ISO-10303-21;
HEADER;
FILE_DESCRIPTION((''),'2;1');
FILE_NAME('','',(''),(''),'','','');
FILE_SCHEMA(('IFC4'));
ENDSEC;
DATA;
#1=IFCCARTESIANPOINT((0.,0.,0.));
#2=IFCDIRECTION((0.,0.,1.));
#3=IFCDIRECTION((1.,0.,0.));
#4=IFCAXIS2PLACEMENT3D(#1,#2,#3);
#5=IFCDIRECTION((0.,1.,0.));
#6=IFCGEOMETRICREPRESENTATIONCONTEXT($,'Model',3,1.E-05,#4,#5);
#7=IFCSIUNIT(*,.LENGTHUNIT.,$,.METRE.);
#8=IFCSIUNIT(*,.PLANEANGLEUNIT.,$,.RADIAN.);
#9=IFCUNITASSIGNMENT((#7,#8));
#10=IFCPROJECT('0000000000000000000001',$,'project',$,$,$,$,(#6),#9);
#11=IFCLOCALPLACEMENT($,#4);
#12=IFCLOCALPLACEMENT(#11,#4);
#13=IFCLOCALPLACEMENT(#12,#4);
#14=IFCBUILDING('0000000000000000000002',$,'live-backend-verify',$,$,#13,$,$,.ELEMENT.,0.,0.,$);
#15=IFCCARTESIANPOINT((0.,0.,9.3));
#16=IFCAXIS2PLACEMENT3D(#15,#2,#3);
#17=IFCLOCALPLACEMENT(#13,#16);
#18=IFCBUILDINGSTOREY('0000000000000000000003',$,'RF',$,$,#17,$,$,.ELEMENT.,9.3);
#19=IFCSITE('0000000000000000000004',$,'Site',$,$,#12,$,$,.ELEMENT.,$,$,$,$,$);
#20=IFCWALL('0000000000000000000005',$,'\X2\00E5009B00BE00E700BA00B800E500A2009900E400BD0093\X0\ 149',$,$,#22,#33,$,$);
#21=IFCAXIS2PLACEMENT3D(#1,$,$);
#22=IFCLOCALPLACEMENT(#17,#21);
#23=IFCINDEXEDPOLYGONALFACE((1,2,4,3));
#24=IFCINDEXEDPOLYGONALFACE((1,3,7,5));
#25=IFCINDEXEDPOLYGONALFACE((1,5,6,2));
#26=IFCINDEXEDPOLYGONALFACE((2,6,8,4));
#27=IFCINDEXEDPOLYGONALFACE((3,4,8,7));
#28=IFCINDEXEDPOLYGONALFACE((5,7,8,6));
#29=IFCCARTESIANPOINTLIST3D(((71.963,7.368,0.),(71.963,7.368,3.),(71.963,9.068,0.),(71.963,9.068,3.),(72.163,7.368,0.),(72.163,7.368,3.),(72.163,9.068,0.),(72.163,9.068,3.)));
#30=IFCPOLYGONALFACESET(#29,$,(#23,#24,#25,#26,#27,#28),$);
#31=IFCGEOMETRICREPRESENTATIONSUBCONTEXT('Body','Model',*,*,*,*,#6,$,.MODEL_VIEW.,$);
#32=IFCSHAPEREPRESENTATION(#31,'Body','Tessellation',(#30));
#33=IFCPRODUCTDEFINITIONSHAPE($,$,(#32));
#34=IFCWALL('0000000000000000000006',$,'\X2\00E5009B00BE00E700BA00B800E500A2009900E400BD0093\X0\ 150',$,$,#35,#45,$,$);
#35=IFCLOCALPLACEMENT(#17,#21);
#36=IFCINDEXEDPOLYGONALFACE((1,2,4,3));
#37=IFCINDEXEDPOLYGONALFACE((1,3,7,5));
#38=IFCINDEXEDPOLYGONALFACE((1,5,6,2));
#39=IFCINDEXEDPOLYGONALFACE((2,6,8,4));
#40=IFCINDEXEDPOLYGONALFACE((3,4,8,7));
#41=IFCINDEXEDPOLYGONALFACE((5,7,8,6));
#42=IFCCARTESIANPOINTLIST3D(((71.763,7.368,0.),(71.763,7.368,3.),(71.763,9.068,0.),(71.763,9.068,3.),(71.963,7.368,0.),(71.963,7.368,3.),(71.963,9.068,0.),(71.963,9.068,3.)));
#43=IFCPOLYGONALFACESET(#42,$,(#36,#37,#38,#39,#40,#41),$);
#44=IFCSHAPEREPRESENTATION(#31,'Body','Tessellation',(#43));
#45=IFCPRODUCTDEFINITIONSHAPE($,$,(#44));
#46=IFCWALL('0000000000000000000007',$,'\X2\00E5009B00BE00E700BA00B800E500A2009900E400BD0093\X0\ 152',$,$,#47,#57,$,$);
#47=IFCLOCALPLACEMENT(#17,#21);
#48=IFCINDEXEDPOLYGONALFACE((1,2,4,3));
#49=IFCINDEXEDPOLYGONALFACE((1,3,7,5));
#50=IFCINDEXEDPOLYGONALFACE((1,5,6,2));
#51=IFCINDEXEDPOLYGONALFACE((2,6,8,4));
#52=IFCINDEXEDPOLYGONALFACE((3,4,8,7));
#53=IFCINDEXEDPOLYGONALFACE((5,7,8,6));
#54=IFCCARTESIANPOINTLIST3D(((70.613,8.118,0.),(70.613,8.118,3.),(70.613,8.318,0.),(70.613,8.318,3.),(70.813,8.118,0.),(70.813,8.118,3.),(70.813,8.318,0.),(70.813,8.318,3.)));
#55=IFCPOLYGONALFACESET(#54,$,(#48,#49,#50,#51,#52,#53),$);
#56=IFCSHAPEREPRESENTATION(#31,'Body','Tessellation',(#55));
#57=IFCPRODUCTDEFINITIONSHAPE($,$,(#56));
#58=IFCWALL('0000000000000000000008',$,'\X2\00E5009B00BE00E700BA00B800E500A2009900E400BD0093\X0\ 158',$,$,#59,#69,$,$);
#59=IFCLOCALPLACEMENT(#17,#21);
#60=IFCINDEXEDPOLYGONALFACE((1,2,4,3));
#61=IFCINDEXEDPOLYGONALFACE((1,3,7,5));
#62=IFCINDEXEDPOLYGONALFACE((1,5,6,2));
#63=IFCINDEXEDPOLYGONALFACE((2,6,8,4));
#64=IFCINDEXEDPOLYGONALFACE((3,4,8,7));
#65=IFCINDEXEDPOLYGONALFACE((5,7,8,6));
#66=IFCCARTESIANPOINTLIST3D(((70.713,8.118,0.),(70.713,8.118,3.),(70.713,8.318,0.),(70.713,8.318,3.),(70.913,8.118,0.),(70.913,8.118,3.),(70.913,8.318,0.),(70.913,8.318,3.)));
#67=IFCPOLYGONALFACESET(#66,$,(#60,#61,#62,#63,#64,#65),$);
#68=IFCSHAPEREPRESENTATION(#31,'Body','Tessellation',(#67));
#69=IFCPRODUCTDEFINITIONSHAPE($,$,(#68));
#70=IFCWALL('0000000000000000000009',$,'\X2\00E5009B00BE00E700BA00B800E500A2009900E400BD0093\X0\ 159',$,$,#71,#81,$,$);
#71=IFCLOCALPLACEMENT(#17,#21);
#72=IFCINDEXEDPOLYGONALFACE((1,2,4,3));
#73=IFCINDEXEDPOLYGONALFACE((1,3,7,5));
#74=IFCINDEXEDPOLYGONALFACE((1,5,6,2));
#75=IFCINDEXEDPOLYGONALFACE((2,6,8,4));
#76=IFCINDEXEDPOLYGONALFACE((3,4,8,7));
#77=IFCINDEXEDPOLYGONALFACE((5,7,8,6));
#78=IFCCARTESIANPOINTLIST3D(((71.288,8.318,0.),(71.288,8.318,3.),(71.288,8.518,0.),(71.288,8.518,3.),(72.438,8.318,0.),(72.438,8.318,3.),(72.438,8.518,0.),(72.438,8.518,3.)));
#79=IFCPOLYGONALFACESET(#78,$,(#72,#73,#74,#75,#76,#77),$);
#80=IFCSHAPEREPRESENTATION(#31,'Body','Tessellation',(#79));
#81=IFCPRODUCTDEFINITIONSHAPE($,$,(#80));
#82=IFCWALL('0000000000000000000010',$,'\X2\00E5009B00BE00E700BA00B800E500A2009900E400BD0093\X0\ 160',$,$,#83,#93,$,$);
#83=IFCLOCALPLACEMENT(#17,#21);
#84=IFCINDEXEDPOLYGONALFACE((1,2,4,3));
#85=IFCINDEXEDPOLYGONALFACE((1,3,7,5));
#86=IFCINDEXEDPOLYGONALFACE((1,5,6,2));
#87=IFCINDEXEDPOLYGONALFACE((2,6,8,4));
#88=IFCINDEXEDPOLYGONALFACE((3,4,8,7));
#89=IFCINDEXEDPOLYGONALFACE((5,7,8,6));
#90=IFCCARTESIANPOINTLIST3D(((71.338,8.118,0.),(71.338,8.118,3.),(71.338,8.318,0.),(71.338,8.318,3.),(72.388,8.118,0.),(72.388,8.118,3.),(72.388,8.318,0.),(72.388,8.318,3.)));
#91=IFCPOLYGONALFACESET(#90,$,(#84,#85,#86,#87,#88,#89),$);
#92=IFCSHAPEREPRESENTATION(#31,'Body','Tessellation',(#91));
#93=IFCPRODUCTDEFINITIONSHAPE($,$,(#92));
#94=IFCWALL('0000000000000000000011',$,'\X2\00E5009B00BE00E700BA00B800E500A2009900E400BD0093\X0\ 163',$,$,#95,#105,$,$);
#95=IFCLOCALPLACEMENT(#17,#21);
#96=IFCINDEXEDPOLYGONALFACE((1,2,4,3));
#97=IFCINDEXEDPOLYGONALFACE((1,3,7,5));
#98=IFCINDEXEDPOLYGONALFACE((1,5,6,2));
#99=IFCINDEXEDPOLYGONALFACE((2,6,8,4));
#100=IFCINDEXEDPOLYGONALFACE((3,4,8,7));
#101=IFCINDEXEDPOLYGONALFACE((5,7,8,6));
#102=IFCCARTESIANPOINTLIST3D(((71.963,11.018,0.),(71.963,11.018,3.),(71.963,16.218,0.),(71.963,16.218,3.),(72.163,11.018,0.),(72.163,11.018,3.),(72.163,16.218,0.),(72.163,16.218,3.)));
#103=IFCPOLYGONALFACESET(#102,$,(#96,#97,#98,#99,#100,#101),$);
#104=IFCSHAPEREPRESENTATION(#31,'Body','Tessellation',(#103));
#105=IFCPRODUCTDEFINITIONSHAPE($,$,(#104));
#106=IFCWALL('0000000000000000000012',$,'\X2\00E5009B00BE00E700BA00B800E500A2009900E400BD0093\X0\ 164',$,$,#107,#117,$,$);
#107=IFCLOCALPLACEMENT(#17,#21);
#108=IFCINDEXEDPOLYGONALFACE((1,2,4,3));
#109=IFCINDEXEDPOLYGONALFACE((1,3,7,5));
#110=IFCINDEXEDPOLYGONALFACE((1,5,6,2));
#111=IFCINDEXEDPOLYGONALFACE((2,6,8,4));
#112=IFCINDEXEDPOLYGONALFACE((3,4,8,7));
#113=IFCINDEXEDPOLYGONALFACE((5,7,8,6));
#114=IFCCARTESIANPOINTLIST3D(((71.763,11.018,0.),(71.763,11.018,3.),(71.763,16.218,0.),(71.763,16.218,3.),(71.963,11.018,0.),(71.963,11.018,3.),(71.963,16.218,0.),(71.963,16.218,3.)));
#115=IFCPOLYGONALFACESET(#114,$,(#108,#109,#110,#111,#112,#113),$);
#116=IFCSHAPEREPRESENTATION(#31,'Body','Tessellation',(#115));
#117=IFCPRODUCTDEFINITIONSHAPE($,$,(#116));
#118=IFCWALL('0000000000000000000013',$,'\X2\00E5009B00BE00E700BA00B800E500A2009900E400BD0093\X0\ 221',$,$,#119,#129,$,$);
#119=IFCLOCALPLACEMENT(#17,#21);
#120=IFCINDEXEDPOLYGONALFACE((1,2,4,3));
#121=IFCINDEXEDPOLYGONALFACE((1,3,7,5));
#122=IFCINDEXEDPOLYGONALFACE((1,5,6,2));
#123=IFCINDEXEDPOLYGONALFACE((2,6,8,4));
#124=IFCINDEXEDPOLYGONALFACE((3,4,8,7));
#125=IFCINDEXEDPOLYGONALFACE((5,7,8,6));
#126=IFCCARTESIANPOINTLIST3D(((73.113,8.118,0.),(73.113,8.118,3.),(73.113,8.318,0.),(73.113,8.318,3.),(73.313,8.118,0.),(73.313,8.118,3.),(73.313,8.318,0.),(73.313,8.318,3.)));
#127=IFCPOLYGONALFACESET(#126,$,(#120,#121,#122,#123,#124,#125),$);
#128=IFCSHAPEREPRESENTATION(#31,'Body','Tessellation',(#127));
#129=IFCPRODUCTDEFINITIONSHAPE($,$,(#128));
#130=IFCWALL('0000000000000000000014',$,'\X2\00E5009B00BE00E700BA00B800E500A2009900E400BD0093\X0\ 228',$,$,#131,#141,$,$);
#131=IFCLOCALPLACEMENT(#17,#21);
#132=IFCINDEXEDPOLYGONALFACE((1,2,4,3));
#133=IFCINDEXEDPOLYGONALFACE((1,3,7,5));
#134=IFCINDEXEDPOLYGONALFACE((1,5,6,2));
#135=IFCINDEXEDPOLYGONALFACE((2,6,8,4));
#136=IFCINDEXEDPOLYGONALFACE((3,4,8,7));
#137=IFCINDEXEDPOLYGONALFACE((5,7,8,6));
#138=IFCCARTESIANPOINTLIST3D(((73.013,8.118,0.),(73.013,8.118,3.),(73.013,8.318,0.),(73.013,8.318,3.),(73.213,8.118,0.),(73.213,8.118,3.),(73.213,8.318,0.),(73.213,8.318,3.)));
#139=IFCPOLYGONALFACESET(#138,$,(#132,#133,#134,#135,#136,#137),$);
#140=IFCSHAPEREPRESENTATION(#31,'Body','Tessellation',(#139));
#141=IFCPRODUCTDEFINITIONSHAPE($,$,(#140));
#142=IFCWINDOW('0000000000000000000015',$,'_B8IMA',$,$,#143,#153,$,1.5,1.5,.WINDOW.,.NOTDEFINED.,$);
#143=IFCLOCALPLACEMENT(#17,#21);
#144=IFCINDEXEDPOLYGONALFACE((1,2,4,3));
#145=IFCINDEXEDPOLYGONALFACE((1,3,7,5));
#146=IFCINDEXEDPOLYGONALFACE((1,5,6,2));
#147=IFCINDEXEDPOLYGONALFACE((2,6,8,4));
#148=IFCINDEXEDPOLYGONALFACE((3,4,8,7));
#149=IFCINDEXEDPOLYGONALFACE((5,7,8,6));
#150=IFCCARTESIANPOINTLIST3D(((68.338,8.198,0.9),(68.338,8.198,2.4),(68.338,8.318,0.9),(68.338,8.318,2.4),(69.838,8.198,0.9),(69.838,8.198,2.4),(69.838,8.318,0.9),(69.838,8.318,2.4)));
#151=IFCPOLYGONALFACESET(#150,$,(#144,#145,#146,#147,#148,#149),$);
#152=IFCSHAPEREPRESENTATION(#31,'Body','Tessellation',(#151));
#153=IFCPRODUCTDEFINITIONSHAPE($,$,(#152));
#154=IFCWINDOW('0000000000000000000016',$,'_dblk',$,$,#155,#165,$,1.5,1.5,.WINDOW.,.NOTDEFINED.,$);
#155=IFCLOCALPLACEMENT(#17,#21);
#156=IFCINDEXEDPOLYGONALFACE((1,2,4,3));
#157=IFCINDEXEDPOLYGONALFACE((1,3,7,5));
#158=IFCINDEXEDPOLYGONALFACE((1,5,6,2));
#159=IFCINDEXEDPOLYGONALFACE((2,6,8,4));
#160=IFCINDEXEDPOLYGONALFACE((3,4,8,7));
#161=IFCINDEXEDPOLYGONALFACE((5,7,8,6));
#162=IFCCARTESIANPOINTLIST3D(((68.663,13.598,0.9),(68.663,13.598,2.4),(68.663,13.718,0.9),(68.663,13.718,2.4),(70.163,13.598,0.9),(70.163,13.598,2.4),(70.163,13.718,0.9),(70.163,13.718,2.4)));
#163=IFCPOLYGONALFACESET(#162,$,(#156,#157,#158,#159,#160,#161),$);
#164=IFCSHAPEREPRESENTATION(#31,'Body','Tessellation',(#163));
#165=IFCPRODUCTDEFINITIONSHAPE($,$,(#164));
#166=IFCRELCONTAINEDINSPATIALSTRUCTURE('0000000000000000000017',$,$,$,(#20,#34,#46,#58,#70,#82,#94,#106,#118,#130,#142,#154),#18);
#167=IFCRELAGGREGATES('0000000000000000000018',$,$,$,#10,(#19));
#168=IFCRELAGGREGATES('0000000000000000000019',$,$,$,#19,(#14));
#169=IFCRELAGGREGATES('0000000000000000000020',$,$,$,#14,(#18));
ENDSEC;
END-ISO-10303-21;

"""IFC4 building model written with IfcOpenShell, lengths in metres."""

from ifc_helpers import new_model, si_unit, direction, frame, frame_2d, origin_with_axes, place, context, subcontext, project, spatial, rectangle, extrude, element, save


model = new_model("IFC4")

# Units and contexts
model_context = context("Model", 3, precision=1e-05, world=origin_with_axes(), true_north=direction((0.0, 1.0, 0.0)))
body_context = subcontext(model_context, "Body", "Model", "MODEL_VIEW")
ifc_project = project(units=[si_unit("LENGTHUNIT", "METRE"), si_unit("PLANEANGLEUNIT", "RADIAN")], contexts=[model_context])

# Site, building, storey
placement = place(None, origin_with_axes())
site_placement = place(placement, origin_with_axes())
site = spatial("IfcSite", under=ifc_project, at=site_placement, Name="Site", CompositionType="ELEMENT")
building_placement = place(site_placement, origin_with_axes())
building = spatial("IfcBuilding", under=site, at=building_placement, Name="live-backend-verify", CompositionType="ELEMENT", ElevationOfRefHeight=0.0, ElevationOfTerrain=0.0)
storey_placement = place(building_placement, frame((0.0, 0.0, 9.3), z_axis=(0.0, 0.0, 1.0), x_axis=(1.0, 0.0, 0.0)))
storey = spatial("IfcBuildingStorey", under=building, at=storey_placement, Name="RF", CompositionType="ELEMENT", Elevation=9.3)

# Walls
for number, where, z_axis, x_axis, name in (
    (1, (72.063, 8.218, 0.0), (0.0, 0.0, 1.0), (0.0, -1.0, 0.0), "å\u009b¾çº¸å¢\u0099ä½\u0093 149"),
    (2, (71.863, 8.218, 0.0), (0.0, 0.0, 1.0), (0.0, -1.0, 0.0), "å\u009b¾çº¸å¢\u0099ä½\u0093 150"),
):
    element("IfcWall", number, at=place(storey_placement, frame(where, z_axis=z_axis, x_axis=x_axis)), inside=storey, Name=name, context=body_context, shape_type="SweptSolid", body=[
        extrude(rectangle(XDim=1.7, YDim=0.2, at=frame_2d((0.0, 0.0), x_axis=(1.0, 0.0, 0.0))), frame((0.0, 0.0, 0.0), z_axis=(0.0, 0.0, 1.0)), (0.0, 0.0, 1.0), 3.0),
    ])
for number, where, z_axis, x_axis, name in (
    (3, (70.713, 8.218, 0.0), (0.0, 0.0, 1.0), (0.0, 1.0, 0.0), "å\u009b¾çº¸å¢\u0099ä½\u0093 152"),
    (4, (70.813, 8.218, 0.0), (0.0, 0.0, 1.0), (0.0, -1.0, 0.0), "å\u009b¾çº¸å¢\u0099ä½\u0093 158"),
):
    element("IfcWall", number, at=place(storey_placement, frame(where, z_axis=z_axis, x_axis=x_axis)), inside=storey, Name=name, context=body_context, shape_type="SweptSolid", body=[
        extrude(rectangle(XDim=0.2, YDim=0.2, at=frame_2d((0.0, 0.0), x_axis=(1.0, 0.0, 0.0))), frame((0.0, 0.0, 0.0), z_axis=(0.0, 0.0, 1.0)), (0.0, 0.0, 1.0), 3.0),
    ])
wall_1_placement = place(storey_placement, frame((71.863, 8.418, 0.0), z_axis=(0.0, 0.0, 1.0), x_axis=(-1.0, 0.0, 0.0)))
element("IfcWall", 5, at=wall_1_placement, inside=storey, Name="å\u009b¾çº¸å¢\u0099ä½\u0093 159", context=body_context, shape_type="SweptSolid", body=[
    extrude(rectangle(XDim=1.15, YDim=0.2, at=frame_2d((0.0, 0.0), x_axis=(1.0, 0.0, 0.0))), frame((0.0, 0.0, 0.0), z_axis=(0.0, 0.0, 1.0)), (0.0, 0.0, 1.0), 3.0),
])
wall_2_placement = place(storey_placement, frame((71.863, 8.218, 0.0), z_axis=(0.0, 0.0, 1.0), x_axis=(-1.0, 0.0, 0.0)))
element("IfcWall", 6, at=wall_2_placement, inside=storey, Name="å\u009b¾çº¸å¢\u0099ä½\u0093 160", context=body_context, shape_type="SweptSolid", body=[
    extrude(rectangle(XDim=1.05, YDim=0.2, at=frame_2d((0.0, 0.0), x_axis=(1.0, 0.0, 0.0))), frame((0.0, 0.0, 0.0), z_axis=(0.0, 0.0, 1.0)), (0.0, 0.0, 1.0), 3.0),
])
for number, where, z_axis, x_axis, name in (
    (7, (72.063, 13.618, 0.0), (0.0, 0.0, 1.0), (0.0, -1.0, 0.0), "å\u009b¾çº¸å¢\u0099ä½\u0093 163"),
    (8, (71.863, 13.618, 0.0), (0.0, 0.0, 1.0), (0.0, -1.0, 0.0), "å\u009b¾çº¸å¢\u0099ä½\u0093 164"),
):
    element("IfcWall", number, at=place(storey_placement, frame(where, z_axis=z_axis, x_axis=x_axis)), inside=storey, Name=name, context=body_context, shape_type="SweptSolid", body=[
        extrude(rectangle(XDim=5.2, YDim=0.2, at=frame_2d((0.0, 0.0), x_axis=(1.0, 0.0, 0.0))), frame((0.0, 0.0, 0.0), z_axis=(0.0, 0.0, 1.0)), (0.0, 0.0, 1.0), 3.0),
    ])
for number, where, z_axis, x_axis, name in (
    (9, (73.213, 8.218, 0.0), (0.0, 0.0, 1.0), (0.0, 1.0, 0.0), "å\u009b¾çº¸å¢\u0099ä½\u0093 221"),
    (10, (73.113, 8.218, 0.0), (0.0, 0.0, 1.0), (0.0, -1.0, 0.0), "å\u009b¾çº¸å¢\u0099ä½\u0093 228"),
):
    element("IfcWall", number, at=place(storey_placement, frame(where, z_axis=z_axis, x_axis=x_axis)), inside=storey, Name=name, context=body_context, shape_type="SweptSolid", body=[
        extrude(rectangle(XDim=0.2, YDim=0.2, at=frame_2d((0.0, 0.0), x_axis=(1.0, 0.0, 0.0))), frame((0.0, 0.0, 0.0), z_axis=(0.0, 0.0, 1.0)), (0.0, 0.0, 1.0), 3.0),
    ])

# Windows
for number, where, z_axis, x_axis, name in (
    (11, (69.088, 8.258, 0.9), (0.0, 0.0, 1.0), (1.0, 0.0, 0.0), "_B8IMA"),
    (12, (69.413, 13.658, 0.9), (0.0, 0.0, 1.0), (1.0, 0.0, 0.0), "_dblk"),
):
    element("IfcWindow", number, at=place(storey_placement, frame(where, z_axis=z_axis, x_axis=x_axis)), inside=storey, Name=name, OverallHeight=1.5, OverallWidth=1.5, PartitioningType="NOTDEFINED", PredefinedType="WINDOW", context=body_context, shape_type="SweptSolid", body=[
        extrude(rectangle(XDim=1.5, YDim=0.12, at=frame_2d((0.0, 0.0), x_axis=(1.0, 0.0, 0.0))), frame((0.0, 0.0, 0.0), z_axis=(0.0, 0.0, 1.0)), (0.0, 0.0, 1.0), 1.5),
    ])

save(model, "model.ifc")
